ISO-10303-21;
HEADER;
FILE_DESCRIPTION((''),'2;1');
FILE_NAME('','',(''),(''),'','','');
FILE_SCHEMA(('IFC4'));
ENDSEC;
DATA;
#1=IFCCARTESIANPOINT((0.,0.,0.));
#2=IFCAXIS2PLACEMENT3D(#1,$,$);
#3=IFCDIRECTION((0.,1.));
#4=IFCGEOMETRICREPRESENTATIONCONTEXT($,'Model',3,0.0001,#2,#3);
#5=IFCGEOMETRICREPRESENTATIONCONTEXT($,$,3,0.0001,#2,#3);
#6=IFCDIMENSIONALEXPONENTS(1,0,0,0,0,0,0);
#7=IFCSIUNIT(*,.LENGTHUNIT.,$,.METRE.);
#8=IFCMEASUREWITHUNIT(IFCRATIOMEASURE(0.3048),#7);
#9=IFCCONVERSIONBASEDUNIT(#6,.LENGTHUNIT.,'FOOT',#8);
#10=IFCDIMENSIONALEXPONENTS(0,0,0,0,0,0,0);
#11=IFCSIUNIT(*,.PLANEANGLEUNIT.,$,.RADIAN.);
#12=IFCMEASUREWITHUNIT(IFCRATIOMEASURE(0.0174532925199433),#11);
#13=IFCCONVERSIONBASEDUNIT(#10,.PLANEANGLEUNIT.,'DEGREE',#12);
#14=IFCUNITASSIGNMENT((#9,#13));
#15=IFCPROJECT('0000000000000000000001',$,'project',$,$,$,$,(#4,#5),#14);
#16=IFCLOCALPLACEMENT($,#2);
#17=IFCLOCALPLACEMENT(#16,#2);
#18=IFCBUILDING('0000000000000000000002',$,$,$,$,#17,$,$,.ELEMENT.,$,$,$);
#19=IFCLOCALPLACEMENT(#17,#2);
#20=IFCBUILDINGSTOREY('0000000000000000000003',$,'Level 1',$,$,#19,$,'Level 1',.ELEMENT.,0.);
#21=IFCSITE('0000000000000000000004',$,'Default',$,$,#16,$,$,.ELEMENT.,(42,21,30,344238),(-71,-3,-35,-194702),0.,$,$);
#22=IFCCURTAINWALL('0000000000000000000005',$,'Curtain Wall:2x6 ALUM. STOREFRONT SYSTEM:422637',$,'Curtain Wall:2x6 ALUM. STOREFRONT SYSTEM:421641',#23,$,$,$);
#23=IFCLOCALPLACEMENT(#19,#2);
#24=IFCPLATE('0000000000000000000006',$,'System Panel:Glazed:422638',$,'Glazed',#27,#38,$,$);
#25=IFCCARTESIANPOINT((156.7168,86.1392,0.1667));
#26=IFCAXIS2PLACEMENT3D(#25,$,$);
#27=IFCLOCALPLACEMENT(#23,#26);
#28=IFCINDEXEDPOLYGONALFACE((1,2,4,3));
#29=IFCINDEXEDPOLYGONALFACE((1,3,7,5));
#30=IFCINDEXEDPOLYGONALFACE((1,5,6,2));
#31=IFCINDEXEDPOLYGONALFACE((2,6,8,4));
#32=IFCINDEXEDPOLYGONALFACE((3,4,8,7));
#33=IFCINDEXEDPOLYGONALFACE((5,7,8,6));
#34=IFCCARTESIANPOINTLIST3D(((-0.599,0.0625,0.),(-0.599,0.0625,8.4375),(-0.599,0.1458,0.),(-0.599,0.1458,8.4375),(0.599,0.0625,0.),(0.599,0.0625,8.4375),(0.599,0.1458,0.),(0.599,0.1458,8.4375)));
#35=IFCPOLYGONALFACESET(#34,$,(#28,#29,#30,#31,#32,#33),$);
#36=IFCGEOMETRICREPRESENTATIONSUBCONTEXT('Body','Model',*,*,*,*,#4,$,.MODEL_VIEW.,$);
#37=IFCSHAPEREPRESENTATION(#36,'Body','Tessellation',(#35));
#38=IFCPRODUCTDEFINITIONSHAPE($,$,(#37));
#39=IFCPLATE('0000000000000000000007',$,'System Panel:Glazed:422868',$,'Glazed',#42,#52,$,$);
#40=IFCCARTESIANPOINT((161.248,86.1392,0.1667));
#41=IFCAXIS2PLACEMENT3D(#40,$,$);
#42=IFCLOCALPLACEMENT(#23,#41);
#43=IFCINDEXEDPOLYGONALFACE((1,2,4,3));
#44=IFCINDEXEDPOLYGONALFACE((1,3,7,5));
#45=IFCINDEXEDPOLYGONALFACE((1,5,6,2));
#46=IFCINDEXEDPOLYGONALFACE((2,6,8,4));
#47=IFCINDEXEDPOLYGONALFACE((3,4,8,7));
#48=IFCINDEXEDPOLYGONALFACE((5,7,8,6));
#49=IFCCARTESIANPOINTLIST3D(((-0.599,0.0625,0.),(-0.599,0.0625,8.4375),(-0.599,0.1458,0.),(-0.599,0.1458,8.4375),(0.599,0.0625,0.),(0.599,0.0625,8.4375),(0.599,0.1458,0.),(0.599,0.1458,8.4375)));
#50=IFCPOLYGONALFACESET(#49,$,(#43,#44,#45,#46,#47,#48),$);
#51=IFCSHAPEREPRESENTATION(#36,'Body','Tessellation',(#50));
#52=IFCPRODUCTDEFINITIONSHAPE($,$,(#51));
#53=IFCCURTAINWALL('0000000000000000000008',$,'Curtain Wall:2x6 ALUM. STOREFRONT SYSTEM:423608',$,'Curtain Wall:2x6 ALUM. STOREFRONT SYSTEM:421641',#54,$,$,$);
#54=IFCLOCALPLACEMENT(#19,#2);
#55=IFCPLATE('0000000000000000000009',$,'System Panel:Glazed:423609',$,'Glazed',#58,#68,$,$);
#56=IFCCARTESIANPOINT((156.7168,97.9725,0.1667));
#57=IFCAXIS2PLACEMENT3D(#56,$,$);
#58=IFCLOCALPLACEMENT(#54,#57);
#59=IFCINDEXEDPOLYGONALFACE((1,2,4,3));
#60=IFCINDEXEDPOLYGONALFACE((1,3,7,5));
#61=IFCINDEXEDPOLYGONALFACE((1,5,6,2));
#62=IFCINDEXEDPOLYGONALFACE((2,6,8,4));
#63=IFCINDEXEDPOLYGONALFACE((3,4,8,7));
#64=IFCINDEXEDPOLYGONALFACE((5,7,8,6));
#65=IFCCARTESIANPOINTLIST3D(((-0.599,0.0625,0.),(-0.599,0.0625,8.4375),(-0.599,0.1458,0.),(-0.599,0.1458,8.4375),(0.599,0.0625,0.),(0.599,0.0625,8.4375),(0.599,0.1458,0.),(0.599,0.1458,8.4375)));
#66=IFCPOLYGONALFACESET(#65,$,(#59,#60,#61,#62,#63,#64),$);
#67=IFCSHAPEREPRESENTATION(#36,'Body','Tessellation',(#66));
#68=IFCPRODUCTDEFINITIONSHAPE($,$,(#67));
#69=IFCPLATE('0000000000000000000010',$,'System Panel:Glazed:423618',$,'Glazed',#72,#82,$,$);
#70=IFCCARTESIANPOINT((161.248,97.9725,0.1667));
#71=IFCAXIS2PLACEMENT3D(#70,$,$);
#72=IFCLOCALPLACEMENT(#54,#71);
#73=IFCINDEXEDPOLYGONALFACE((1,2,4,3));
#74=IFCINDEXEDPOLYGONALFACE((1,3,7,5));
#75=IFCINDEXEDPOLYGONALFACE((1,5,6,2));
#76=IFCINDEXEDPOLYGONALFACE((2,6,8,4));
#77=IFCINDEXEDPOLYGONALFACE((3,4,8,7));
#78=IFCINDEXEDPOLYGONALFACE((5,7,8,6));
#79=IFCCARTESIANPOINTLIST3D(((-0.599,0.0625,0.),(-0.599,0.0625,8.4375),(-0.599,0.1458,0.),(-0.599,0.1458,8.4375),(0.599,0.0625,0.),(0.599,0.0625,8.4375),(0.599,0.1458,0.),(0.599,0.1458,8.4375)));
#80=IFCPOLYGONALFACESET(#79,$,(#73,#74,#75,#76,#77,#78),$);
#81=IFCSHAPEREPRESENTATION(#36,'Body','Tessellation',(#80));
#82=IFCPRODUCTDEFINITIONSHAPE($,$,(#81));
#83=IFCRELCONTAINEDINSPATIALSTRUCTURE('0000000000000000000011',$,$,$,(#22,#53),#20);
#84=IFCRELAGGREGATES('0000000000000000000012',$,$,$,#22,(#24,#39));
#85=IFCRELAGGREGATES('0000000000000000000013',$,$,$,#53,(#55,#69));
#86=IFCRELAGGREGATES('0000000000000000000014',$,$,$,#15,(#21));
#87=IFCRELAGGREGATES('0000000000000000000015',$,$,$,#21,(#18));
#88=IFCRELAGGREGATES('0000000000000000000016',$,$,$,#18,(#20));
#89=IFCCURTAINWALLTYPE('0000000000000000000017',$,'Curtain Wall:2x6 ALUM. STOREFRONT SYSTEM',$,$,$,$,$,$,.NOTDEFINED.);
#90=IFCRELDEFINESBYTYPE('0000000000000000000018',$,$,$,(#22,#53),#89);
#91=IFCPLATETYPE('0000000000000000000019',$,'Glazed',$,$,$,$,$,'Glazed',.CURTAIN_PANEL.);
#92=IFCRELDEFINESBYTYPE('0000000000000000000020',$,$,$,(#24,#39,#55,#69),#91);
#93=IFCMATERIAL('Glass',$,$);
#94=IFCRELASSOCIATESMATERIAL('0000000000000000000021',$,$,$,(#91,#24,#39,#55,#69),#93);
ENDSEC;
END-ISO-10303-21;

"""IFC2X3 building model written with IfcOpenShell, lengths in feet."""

from ifc_helpers import new_model, entity, si_unit, converted_unit, direction, frame, frame_2d, origin, place, context, subcontext, project, spatial, rectangle, extrude, source, transform, mapped, material, type_object, type_shapes, element, aggregate, save


model = new_model("IFC2X3")

# Units and contexts
model_context = context("Model", 3, precision=0.0001, world=origin(), true_north=direction((0.0, 1.0)))
context_of_model = context(None, 3, precision=0.0001, world=origin(), true_north=direction((0.0, 1.0)))
body_context = subcontext(model_context, "Body", "Model", "MODEL_VIEW")
ifc_project = project(units=[converted_unit("LENGTHUNIT", "FOOT", entity("IfcRatioMeasure", 0.3048), si_unit("LENGTHUNIT", "METRE"), dimensions=[1, 0, 0, 0, 0, 0, 0]), converted_unit("PLANEANGLEUNIT", "DEGREE", entity("IfcRatioMeasure", 0.0174532925199433), si_unit("PLANEANGLEUNIT", "RADIAN"), dimensions=[0, 0, 0, 0, 0, 0, 0])], contexts=[model_context, context_of_model])

# Site, building, storey
site_placement = place(None, origin())
site = spatial("IfcSite", under=ifc_project, at=site_placement, Name="Default", CompositionType="ELEMENT", RefLatitude=(42, 21, 30, 344238), RefLongitude=(-71, -3, -35, -194702), RefElevation=0.0)
building_placement = place(site_placement, origin())
building = spatial("IfcBuilding", under=site, at=building_placement, CompositionType="ELEMENT")
storey_placement = place(building_placement, origin())
storey = spatial("IfcBuildingStorey", under=building, at=storey_placement, Name="Level 1", LongName="Level 1", CompositionType="ELEMENT", Elevation=0.0)

# Curtain walls, plates
curtain_wall_type = type_object("IfcCurtainWallType", Name="Curtain Wall:2x6 ALUM. STOREFRONT SYSTEM", PredefinedType="NOTDEFINED")
curtain_wall_1_placement = place(storey_placement, origin())
curtain_wall_1 = element("IfcCurtainWall", 1, at=curtain_wall_1_placement, inside=storey, type_object=curtain_wall_type, Name="Curtain Wall:2x6 ALUM. STOREFRONT SYSTEM:422637", ObjectType="Curtain Wall:2x6 ALUM. STOREFRONT SYSTEM:421641")
ifc_material_1 = material(Name="Glass")
plate_type = type_object("IfcPlateType", Name="Glazed", ElementType="Glazed", PredefinedType="CURTAIN_PANEL", material=ifc_material_1)
shared_shape_1 = source(origin(), body_context, "Body", "SweptSolid", [
    extrude(rectangle(XDim=0.0833, YDim=1.1979, at=frame_2d((0.0, 0.0), x_axis=(1.0, 0.0))), frame((0.0, 0.1042, 0.0), z_axis=(0.0, 0.0, 1.0), x_axis=(0.0, 1.0, 0.0)), (0.0, 0.0, 1.0), 8.4375),
])
type_shapes(plate_type, [shared_shape_1])
plate_1_placement = place(curtain_wall_1_placement, frame((156.7168, 86.1392, 0.1667)))
plate_1 = element("IfcPlate", 2, at=plate_1_placement, type_object=plate_type, material=ifc_material_1, Name="System Panel:Glazed:422638", ObjectType="Glazed", context=body_context, shape_type="MappedRepresentation", body=[
    mapped(shared_shape_1, transform((0.0, 0.0, 0.0), scale=1.0)),
])
plate_2_placement = place(curtain_wall_1_placement, frame((161.248, 86.1392, 0.1667)))
plate_2 = element("IfcPlate", 3, at=plate_2_placement, type_object=plate_type, material=ifc_material_1, Name="System Panel:Glazed:422868", ObjectType="Glazed", context=body_context, shape_type="MappedRepresentation", body=[
    mapped(shared_shape_1, transform((0.0, 0.0, 0.0), scale=1.0)),
])
curtain_wall_2_placement = place(storey_placement, origin())
curtain_wall_2 = element("IfcCurtainWall", 4, at=curtain_wall_2_placement, inside=storey, type_object=curtain_wall_type, Name="Curtain Wall:2x6 ALUM. STOREFRONT SYSTEM:423608", ObjectType="Curtain Wall:2x6 ALUM. STOREFRONT SYSTEM:421641")
plate_3_placement = place(curtain_wall_2_placement, frame((156.7168, 97.9725, 0.1667)))
plate_3 = element("IfcPlate", 5, at=plate_3_placement, type_object=plate_type, material=ifc_material_1, Name="System Panel:Glazed:423609", ObjectType="Glazed", context=body_context, shape_type="MappedRepresentation", body=[
    mapped(shared_shape_1, transform((0.0, 0.0, 0.0), scale=1.0)),
])
plate_4_placement = place(curtain_wall_2_placement, frame((161.248, 97.9725, 0.1667)))
plate_4 = element("IfcPlate", 6, at=plate_4_placement, type_object=plate_type, material=ifc_material_1, Name="System Panel:Glazed:423618", ObjectType="Glazed", context=body_context, shape_type="MappedRepresentation", body=[
    mapped(shared_shape_1, transform((0.0, 0.0, 0.0), scale=1.0)),
])

aggregate(curtain_wall_1, [plate_1, plate_2])
aggregate(curtain_wall_2, [plate_3, plate_4])

save(model, "model.ifc")
